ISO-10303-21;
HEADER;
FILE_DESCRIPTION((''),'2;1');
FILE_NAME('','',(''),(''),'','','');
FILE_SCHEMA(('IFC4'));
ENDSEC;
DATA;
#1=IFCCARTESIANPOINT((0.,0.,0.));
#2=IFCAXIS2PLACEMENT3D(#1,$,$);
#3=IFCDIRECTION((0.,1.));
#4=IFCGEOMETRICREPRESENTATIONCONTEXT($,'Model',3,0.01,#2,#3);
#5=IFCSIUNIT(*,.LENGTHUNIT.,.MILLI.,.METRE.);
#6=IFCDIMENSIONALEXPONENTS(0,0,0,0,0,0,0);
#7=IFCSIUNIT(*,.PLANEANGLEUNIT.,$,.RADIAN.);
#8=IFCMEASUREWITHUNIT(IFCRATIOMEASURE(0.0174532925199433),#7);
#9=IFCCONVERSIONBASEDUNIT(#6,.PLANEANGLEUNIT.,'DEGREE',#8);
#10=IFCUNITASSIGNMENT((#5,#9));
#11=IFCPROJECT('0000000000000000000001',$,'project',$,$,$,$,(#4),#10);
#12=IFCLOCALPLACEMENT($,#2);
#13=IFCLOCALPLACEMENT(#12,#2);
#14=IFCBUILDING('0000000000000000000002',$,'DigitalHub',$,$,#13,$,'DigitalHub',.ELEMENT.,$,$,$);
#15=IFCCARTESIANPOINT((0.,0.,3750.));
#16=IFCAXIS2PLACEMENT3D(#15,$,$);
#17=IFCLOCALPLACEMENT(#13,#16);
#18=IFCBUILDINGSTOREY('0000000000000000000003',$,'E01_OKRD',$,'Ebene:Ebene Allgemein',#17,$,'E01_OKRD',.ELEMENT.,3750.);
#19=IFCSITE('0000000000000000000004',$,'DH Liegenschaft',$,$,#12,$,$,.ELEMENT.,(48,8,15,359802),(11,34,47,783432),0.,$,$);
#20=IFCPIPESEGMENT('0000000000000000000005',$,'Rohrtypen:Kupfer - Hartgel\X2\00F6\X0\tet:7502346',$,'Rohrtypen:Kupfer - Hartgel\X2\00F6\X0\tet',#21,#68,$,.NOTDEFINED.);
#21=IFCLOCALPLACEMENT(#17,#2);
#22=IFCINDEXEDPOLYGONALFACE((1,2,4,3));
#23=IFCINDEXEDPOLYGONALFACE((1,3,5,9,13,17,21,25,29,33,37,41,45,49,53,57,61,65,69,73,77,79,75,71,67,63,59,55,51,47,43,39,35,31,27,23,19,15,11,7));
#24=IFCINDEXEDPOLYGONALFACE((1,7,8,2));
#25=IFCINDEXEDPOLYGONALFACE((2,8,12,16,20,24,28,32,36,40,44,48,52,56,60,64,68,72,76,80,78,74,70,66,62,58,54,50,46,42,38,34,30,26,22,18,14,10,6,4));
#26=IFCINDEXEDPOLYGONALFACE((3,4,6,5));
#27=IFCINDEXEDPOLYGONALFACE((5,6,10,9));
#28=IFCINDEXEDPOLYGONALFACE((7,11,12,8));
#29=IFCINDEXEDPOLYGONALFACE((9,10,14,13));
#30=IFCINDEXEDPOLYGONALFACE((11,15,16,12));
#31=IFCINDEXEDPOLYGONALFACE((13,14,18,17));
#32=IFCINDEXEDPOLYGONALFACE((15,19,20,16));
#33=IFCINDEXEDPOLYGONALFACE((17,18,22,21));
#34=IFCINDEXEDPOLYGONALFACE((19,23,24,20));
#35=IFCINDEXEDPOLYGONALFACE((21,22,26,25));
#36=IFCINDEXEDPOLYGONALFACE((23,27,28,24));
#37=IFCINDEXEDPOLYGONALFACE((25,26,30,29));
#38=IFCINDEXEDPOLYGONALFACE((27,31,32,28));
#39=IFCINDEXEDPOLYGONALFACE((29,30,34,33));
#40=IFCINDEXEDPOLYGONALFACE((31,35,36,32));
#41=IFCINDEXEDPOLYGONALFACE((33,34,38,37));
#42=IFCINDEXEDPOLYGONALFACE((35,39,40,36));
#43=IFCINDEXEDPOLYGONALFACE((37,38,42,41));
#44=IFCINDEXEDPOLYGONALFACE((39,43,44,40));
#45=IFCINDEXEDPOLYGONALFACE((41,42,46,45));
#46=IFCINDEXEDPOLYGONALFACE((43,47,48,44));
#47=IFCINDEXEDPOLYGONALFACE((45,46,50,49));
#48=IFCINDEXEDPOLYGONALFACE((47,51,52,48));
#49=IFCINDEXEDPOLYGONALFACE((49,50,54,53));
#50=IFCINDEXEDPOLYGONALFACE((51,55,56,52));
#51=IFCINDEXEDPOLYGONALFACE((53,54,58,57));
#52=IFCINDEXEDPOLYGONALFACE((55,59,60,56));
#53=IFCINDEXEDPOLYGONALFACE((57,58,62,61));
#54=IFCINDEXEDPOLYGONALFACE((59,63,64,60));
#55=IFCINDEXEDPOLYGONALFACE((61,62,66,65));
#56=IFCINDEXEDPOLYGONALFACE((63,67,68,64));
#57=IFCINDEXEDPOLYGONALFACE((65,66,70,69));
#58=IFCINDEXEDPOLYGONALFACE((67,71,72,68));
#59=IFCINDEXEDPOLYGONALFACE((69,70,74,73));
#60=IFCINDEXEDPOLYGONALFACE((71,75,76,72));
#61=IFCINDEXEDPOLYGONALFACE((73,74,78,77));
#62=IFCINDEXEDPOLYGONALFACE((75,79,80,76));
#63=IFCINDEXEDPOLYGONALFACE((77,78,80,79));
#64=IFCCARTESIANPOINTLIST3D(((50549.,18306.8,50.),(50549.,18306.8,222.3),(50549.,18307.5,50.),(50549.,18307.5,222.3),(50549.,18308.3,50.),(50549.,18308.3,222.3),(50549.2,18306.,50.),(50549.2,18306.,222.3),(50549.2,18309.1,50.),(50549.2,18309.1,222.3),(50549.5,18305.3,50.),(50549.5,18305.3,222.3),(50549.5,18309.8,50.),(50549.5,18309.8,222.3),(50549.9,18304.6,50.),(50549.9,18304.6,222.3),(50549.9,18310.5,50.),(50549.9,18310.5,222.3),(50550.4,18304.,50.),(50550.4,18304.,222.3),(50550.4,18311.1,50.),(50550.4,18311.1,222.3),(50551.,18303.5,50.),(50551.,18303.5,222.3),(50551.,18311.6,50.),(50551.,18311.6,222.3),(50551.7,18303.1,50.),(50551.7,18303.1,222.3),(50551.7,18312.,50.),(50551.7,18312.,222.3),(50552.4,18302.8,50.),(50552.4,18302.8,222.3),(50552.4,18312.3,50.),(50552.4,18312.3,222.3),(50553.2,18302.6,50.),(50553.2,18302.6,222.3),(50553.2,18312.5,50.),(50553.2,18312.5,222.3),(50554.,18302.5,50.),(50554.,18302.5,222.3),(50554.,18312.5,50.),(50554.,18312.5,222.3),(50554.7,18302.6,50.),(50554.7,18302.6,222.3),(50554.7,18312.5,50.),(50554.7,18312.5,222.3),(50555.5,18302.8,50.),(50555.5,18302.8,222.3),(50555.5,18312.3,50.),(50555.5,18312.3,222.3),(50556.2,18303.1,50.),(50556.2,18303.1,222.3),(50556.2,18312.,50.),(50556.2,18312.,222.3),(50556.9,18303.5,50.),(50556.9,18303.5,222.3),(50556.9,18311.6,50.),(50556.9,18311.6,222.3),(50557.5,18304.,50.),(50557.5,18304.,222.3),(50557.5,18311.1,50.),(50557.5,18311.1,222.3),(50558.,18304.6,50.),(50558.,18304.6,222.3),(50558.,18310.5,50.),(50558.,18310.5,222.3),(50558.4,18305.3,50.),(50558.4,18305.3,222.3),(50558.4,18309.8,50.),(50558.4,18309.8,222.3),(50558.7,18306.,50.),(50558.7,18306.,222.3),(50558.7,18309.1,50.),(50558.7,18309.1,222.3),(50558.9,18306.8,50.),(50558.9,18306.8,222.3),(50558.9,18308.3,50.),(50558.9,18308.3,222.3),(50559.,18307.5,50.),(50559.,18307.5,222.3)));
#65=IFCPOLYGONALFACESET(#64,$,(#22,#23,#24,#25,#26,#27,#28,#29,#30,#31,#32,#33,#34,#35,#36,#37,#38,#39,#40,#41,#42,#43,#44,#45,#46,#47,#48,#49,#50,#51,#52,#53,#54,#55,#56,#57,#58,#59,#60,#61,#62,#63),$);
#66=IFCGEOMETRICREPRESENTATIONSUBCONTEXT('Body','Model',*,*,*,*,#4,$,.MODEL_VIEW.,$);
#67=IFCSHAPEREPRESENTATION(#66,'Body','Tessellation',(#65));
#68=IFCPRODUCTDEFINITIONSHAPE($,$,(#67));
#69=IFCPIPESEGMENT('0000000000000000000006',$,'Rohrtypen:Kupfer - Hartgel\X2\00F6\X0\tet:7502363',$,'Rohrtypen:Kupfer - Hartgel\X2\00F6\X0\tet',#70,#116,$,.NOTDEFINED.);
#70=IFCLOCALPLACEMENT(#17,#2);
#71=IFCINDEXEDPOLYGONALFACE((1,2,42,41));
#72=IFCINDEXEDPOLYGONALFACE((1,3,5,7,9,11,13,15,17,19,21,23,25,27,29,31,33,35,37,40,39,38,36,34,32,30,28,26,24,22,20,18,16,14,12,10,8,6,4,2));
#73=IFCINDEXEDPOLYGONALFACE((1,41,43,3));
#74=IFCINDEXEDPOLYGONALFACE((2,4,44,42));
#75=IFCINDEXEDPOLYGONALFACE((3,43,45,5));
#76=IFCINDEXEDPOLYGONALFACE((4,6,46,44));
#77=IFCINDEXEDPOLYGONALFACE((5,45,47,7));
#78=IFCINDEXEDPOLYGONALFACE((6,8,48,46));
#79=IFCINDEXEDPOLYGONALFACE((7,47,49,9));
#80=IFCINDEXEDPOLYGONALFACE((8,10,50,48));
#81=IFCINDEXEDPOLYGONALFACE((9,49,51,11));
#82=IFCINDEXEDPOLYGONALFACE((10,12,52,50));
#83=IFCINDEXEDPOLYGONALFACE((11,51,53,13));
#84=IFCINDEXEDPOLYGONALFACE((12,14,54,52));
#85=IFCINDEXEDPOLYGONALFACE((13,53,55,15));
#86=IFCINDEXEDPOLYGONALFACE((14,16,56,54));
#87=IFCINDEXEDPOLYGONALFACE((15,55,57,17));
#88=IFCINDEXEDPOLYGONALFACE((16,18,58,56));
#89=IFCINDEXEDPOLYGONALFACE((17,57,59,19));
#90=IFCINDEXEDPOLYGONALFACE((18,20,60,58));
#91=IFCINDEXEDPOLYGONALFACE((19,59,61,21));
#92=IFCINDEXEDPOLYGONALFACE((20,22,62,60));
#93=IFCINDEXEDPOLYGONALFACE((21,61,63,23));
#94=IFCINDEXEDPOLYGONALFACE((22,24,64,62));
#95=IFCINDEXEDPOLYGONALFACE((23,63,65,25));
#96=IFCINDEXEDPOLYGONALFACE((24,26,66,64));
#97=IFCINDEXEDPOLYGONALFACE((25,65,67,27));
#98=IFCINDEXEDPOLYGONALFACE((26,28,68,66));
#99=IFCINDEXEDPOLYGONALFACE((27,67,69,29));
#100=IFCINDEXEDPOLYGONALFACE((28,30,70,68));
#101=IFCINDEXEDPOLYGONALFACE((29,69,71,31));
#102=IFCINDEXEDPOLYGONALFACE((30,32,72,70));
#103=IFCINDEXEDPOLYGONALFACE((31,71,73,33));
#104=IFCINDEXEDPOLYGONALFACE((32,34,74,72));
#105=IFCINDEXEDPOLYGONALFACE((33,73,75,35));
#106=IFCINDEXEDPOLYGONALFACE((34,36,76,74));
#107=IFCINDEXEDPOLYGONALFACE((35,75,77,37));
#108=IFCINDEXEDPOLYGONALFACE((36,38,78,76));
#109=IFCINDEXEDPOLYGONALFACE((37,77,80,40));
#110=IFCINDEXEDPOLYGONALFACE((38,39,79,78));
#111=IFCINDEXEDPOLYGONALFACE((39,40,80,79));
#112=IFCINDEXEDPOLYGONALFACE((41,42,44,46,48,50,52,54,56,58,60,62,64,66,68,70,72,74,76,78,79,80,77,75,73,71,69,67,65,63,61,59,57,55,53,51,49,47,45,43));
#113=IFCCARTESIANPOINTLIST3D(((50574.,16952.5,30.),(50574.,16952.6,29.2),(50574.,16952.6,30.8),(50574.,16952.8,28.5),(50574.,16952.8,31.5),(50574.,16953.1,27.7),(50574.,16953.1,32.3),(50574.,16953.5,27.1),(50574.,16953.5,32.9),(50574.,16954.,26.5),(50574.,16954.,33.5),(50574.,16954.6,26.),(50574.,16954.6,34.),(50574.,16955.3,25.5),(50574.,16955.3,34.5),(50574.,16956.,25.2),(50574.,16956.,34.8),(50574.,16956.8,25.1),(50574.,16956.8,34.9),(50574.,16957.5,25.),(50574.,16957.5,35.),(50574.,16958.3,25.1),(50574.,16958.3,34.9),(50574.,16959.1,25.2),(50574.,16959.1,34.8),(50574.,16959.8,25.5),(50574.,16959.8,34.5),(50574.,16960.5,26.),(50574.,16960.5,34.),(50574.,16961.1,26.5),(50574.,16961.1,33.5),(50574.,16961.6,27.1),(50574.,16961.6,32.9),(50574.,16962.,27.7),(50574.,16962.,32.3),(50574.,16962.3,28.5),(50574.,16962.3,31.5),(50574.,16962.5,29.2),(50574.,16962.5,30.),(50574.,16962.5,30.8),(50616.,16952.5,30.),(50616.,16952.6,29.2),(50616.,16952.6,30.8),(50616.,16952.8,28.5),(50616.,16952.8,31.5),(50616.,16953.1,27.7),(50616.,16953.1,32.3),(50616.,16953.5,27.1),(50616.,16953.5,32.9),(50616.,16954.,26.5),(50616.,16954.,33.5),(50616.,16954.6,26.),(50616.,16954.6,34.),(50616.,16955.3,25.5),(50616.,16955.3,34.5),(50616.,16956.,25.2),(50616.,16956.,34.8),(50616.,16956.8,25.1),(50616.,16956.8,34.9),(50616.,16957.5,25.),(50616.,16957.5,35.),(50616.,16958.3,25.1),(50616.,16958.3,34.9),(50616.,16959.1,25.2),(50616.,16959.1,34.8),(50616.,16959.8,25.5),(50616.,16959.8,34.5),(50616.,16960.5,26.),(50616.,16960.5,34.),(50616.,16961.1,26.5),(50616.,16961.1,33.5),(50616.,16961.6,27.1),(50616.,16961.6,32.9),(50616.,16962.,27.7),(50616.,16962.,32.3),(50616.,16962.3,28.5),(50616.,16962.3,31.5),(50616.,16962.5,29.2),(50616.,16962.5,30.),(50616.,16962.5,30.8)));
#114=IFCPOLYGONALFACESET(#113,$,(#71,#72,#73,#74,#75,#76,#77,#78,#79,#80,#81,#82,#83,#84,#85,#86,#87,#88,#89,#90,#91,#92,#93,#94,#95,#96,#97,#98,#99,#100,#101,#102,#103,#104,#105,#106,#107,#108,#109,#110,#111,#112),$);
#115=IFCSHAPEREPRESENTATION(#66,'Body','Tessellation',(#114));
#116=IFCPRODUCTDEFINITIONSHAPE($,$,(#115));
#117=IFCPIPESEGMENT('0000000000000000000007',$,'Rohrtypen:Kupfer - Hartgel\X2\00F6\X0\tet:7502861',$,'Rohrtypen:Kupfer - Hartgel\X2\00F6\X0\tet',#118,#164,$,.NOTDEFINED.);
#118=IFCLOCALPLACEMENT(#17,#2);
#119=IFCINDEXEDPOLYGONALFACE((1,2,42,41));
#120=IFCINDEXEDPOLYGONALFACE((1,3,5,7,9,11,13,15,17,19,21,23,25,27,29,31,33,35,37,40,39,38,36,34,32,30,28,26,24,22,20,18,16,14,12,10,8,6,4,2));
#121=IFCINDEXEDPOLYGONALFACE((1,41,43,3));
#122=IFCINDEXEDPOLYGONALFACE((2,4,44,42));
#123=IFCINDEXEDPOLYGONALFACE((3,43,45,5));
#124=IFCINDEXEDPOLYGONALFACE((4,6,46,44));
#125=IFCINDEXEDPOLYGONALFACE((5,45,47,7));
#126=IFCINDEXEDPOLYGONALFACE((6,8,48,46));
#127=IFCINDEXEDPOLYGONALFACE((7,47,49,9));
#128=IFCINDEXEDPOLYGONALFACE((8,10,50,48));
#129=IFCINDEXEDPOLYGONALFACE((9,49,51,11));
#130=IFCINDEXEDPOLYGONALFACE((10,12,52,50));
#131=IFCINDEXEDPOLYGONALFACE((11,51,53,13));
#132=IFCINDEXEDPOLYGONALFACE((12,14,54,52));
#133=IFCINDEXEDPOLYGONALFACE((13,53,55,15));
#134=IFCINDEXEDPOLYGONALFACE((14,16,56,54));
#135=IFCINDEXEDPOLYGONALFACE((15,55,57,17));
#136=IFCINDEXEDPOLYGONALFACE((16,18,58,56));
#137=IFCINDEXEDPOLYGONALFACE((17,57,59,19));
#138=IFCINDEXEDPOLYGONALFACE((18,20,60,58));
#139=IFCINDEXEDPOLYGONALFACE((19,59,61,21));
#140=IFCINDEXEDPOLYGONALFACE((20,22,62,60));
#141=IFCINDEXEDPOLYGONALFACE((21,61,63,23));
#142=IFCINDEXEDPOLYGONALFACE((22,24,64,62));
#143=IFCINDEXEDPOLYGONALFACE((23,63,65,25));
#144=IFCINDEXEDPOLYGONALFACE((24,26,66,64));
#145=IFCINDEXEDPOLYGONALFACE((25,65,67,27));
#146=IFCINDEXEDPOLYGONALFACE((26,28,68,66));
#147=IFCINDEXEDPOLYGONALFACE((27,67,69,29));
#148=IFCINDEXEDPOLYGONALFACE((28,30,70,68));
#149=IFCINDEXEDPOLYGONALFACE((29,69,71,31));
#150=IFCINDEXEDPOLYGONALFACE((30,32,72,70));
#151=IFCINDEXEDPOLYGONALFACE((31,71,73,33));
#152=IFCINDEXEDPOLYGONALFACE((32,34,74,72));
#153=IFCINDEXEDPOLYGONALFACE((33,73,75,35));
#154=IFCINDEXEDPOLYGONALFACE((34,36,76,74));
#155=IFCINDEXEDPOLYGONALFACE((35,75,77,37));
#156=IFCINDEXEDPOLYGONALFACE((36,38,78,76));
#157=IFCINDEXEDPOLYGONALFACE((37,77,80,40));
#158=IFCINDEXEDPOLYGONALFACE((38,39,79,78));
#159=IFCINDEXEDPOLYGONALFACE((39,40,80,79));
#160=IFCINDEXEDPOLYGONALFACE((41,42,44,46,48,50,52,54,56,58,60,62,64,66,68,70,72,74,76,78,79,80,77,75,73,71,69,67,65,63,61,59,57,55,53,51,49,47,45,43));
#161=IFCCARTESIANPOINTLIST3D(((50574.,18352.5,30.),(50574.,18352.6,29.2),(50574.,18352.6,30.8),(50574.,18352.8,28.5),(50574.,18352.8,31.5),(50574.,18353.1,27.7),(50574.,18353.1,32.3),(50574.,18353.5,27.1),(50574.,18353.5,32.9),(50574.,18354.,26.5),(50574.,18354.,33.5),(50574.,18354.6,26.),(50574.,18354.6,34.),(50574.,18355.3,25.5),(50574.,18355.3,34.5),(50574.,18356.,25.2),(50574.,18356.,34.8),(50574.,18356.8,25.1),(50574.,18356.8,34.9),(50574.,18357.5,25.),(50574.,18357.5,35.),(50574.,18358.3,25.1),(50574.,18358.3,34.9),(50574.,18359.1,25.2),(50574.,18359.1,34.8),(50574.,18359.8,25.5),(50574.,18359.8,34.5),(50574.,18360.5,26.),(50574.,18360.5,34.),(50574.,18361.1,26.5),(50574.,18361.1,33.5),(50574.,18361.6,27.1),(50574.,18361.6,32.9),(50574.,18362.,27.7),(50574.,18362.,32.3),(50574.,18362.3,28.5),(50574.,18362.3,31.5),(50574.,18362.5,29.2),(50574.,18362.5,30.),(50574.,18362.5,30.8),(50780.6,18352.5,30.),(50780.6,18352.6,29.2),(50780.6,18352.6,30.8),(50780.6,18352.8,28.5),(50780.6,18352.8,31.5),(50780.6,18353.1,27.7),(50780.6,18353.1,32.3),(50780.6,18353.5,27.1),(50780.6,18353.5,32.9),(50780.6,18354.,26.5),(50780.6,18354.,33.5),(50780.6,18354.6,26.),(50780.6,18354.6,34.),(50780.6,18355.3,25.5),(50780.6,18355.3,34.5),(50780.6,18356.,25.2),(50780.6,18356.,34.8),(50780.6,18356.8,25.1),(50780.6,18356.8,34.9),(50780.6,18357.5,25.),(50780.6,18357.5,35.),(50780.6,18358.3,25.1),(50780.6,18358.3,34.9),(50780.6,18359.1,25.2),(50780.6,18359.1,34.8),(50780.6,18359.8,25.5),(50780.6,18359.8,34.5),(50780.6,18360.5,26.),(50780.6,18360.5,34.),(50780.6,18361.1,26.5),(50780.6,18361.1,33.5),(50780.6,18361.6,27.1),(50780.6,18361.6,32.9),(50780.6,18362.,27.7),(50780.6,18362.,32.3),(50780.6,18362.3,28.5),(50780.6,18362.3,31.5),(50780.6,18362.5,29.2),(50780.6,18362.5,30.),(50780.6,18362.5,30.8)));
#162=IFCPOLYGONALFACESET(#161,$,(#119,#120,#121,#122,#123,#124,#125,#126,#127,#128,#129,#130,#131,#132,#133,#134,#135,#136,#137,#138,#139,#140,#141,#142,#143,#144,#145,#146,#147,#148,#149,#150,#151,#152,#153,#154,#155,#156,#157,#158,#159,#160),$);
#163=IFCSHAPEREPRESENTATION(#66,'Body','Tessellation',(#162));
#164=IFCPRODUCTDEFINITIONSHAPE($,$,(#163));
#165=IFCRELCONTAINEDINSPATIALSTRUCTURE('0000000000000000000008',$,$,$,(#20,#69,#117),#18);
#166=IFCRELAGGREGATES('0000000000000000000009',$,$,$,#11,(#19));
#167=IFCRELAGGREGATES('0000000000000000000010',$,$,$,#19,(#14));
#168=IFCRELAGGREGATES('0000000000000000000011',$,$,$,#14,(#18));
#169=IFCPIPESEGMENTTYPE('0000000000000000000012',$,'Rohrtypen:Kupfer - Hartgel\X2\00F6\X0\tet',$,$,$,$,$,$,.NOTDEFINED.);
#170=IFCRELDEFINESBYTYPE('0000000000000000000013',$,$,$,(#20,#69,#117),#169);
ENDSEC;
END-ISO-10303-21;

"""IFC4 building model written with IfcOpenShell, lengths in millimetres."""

from ifc_helpers import new_model, entity, si_unit, converted_unit, direction, frame, origin, place, context, subcontext, project, spatial, indexed_curve, outline, extrude, type_object, element, save


model = new_model("IFC4")

# Units and contexts
model_context = context("Model", 3, precision=0.01, world=origin(), true_north=direction((0.0, 1.0)))
body_context = subcontext(model_context, "Body", "Model", "MODEL_VIEW")
ifc_project = project(units=[si_unit("LENGTHUNIT", "METRE", prefix="MILLI"), converted_unit("PLANEANGLEUNIT", "DEGREE", entity("IfcRatioMeasure", 0.0174532925199433), si_unit("PLANEANGLEUNIT", "RADIAN"), dimensions=[0, 0, 0, 0, 0, 0, 0])], contexts=[model_context])

# Site, building, storey
site_placement = place(None, origin())
site = spatial("IfcSite", under=ifc_project, at=site_placement, Name="DH Liegenschaft", CompositionType="ELEMENT", RefLatitude=(48, 8, 15, 359802), RefLongitude=(11, 34, 47, 783432), RefElevation=0.0)
building_placement = place(site_placement, origin())
building = spatial("IfcBuilding", under=site, at=building_placement, Name="DigitalHub", LongName="DigitalHub", CompositionType="ELEMENT")
storey_placement = place(building_placement, frame((0.0, 0.0, 3750.0)))
storey = spatial("IfcBuildingStorey", under=building, at=storey_placement, Name="E01_OKRD", ObjectType="Ebene:Ebene Allgemein", LongName="E01_OKRD", CompositionType="ELEMENT", Elevation=3750.0)

# Pipe segments
pipe_segment_type = type_object("IfcPipeSegmentType", Name="Rohrtypen:Kupfer - Hartgelötet", PredefinedType="NOTDEFINED")
pipe_segment_1_placement = place(storey_placement, frame((50547.4, 18300.9, 50.0)))
element("IfcPipeSegment", 1, at=pipe_segment_1_placement, inside=storey, type_object=pipe_segment_type, Name="Rohrtypen:Kupfer - Hartgelötet:7502346", ObjectType="Rohrtypen:Kupfer - Hartgelötet", PredefinedType="NOTDEFINED", context=body_context, shape_type="SweptSolid", body=[
    extrude(outline(indexed_curve([(5.0, 0.0), (4.9, 0.8), (4.8, 1.5), (4.5, 2.3), (4.0, 2.9), (3.5, 3.5), (2.9, 4.0), (2.3, 4.5), (1.5, 4.8), (0.8, 4.9), (0.0, 5.0), (-0.8, 4.9), (-1.5, 4.8), (-2.3, 4.5), (-2.9, 4.0), (-3.5, 3.5), (-4.0, 2.9), (-4.5, 2.3), (-4.8, 1.5), (-4.9, 0.8), (-5.0, 0.0), (-4.9, -0.8), (-4.8, -1.5), (-4.5, -2.3), (-4.0, -2.9), (-3.5, -3.5), (-2.9, -4.0), (-2.3, -4.5), (-1.5, -4.8), (-0.8, -4.9), (0.0, -5.0), (0.8, -4.9), (1.5, -4.8), (2.3, -4.5), (2.9, -4.0), (3.5, -3.5), (4.0, -2.9), (4.5, -2.3), (4.8, -1.5), (4.9, -0.8), (5.0, 0.0)], self_intersect=False)), frame((6.6, 6.6, 0.0)), (0.0, 0.0, 1.0), 172.3),
])
pipe_segment_2_placement = place(storey_placement, frame((50574.0, 16950.9, 23.4)))
element("IfcPipeSegment", 2, at=pipe_segment_2_placement, inside=storey, type_object=pipe_segment_type, Name="Rohrtypen:Kupfer - Hartgelötet:7502363", ObjectType="Rohrtypen:Kupfer - Hartgelötet", PredefinedType="NOTDEFINED", context=body_context, shape_type="SweptSolid", body=[
    extrude(outline(indexed_curve([(5.0, 0.0), (4.9, 0.8), (4.8, 1.5), (4.5, 2.3), (4.0, 2.9), (3.5, 3.5), (2.9, 4.0), (2.3, 4.5), (1.5, 4.8), (0.8, 4.9), (0.0, 5.0), (-0.8, 4.9), (-1.5, 4.8), (-2.3, 4.5), (-2.9, 4.0), (-3.5, 3.5), (-4.0, 2.9), (-4.5, 2.3), (-4.8, 1.5), (-4.9, 0.8), (-5.0, 0.0), (-4.9, -0.8), (-4.8, -1.5), (-4.5, -2.3), (-4.0, -2.9), (-3.5, -3.5), (-2.9, -4.0), (-2.3, -4.5), (-1.5, -4.8), (-0.8, -4.9), (0.0, -5.0), (0.8, -4.9), (1.5, -4.8), (2.3, -4.5), (2.9, -4.0), (3.5, -3.5), (4.0, -2.9), (4.5, -2.3), (4.8, -1.5), (4.9, -0.8), (5.0, 0.0)], self_intersect=False)), frame((0.0, 6.6, 6.6), z_axis=(1.0, 0.0, 0.0), x_axis=(0.0, -1.0, 0.0)), (0.0, 0.0, 1.0), 42.1),
])
pipe_segment_3_placement = place(storey_placement, frame((50574.0, 18350.9, 23.4)))
element("IfcPipeSegment", 3, at=pipe_segment_3_placement, inside=storey, type_object=pipe_segment_type, Name="Rohrtypen:Kupfer - Hartgelötet:7502861", ObjectType="Rohrtypen:Kupfer - Hartgelötet", PredefinedType="NOTDEFINED", context=body_context, shape_type="SweptSolid", body=[
    extrude(outline(indexed_curve([(5.0, 0.0), (4.9, 0.8), (4.8, 1.5), (4.5, 2.3), (4.0, 2.9), (3.5, 3.5), (2.9, 4.0), (2.3, 4.5), (1.5, 4.8), (0.8, 4.9), (0.0, 5.0), (-0.8, 4.9), (-1.5, 4.8), (-2.3, 4.5), (-2.9, 4.0), (-3.5, 3.5), (-4.0, 2.9), (-4.5, 2.3), (-4.8, 1.5), (-4.9, 0.8), (-5.0, 0.0), (-4.9, -0.8), (-4.8, -1.5), (-4.5, -2.3), (-4.0, -2.9), (-3.5, -3.5), (-2.9, -4.0), (-2.3, -4.5), (-1.5, -4.8), (-0.8, -4.9), (0.0, -5.0), (0.8, -4.9), (1.5, -4.8), (2.3, -4.5), (2.9, -4.0), (3.5, -3.5), (4.0, -2.9), (4.5, -2.3), (4.8, -1.5), (4.9, -0.8), (5.0, 0.0)], self_intersect=False)), frame((0.0, 6.6, 6.6), z_axis=(1.0, 0.0, 0.0), x_axis=(0.0, -1.0, 0.0)), (0.0, 0.0, 1.0), 206.6),
])

save(model, "model.ifc")
